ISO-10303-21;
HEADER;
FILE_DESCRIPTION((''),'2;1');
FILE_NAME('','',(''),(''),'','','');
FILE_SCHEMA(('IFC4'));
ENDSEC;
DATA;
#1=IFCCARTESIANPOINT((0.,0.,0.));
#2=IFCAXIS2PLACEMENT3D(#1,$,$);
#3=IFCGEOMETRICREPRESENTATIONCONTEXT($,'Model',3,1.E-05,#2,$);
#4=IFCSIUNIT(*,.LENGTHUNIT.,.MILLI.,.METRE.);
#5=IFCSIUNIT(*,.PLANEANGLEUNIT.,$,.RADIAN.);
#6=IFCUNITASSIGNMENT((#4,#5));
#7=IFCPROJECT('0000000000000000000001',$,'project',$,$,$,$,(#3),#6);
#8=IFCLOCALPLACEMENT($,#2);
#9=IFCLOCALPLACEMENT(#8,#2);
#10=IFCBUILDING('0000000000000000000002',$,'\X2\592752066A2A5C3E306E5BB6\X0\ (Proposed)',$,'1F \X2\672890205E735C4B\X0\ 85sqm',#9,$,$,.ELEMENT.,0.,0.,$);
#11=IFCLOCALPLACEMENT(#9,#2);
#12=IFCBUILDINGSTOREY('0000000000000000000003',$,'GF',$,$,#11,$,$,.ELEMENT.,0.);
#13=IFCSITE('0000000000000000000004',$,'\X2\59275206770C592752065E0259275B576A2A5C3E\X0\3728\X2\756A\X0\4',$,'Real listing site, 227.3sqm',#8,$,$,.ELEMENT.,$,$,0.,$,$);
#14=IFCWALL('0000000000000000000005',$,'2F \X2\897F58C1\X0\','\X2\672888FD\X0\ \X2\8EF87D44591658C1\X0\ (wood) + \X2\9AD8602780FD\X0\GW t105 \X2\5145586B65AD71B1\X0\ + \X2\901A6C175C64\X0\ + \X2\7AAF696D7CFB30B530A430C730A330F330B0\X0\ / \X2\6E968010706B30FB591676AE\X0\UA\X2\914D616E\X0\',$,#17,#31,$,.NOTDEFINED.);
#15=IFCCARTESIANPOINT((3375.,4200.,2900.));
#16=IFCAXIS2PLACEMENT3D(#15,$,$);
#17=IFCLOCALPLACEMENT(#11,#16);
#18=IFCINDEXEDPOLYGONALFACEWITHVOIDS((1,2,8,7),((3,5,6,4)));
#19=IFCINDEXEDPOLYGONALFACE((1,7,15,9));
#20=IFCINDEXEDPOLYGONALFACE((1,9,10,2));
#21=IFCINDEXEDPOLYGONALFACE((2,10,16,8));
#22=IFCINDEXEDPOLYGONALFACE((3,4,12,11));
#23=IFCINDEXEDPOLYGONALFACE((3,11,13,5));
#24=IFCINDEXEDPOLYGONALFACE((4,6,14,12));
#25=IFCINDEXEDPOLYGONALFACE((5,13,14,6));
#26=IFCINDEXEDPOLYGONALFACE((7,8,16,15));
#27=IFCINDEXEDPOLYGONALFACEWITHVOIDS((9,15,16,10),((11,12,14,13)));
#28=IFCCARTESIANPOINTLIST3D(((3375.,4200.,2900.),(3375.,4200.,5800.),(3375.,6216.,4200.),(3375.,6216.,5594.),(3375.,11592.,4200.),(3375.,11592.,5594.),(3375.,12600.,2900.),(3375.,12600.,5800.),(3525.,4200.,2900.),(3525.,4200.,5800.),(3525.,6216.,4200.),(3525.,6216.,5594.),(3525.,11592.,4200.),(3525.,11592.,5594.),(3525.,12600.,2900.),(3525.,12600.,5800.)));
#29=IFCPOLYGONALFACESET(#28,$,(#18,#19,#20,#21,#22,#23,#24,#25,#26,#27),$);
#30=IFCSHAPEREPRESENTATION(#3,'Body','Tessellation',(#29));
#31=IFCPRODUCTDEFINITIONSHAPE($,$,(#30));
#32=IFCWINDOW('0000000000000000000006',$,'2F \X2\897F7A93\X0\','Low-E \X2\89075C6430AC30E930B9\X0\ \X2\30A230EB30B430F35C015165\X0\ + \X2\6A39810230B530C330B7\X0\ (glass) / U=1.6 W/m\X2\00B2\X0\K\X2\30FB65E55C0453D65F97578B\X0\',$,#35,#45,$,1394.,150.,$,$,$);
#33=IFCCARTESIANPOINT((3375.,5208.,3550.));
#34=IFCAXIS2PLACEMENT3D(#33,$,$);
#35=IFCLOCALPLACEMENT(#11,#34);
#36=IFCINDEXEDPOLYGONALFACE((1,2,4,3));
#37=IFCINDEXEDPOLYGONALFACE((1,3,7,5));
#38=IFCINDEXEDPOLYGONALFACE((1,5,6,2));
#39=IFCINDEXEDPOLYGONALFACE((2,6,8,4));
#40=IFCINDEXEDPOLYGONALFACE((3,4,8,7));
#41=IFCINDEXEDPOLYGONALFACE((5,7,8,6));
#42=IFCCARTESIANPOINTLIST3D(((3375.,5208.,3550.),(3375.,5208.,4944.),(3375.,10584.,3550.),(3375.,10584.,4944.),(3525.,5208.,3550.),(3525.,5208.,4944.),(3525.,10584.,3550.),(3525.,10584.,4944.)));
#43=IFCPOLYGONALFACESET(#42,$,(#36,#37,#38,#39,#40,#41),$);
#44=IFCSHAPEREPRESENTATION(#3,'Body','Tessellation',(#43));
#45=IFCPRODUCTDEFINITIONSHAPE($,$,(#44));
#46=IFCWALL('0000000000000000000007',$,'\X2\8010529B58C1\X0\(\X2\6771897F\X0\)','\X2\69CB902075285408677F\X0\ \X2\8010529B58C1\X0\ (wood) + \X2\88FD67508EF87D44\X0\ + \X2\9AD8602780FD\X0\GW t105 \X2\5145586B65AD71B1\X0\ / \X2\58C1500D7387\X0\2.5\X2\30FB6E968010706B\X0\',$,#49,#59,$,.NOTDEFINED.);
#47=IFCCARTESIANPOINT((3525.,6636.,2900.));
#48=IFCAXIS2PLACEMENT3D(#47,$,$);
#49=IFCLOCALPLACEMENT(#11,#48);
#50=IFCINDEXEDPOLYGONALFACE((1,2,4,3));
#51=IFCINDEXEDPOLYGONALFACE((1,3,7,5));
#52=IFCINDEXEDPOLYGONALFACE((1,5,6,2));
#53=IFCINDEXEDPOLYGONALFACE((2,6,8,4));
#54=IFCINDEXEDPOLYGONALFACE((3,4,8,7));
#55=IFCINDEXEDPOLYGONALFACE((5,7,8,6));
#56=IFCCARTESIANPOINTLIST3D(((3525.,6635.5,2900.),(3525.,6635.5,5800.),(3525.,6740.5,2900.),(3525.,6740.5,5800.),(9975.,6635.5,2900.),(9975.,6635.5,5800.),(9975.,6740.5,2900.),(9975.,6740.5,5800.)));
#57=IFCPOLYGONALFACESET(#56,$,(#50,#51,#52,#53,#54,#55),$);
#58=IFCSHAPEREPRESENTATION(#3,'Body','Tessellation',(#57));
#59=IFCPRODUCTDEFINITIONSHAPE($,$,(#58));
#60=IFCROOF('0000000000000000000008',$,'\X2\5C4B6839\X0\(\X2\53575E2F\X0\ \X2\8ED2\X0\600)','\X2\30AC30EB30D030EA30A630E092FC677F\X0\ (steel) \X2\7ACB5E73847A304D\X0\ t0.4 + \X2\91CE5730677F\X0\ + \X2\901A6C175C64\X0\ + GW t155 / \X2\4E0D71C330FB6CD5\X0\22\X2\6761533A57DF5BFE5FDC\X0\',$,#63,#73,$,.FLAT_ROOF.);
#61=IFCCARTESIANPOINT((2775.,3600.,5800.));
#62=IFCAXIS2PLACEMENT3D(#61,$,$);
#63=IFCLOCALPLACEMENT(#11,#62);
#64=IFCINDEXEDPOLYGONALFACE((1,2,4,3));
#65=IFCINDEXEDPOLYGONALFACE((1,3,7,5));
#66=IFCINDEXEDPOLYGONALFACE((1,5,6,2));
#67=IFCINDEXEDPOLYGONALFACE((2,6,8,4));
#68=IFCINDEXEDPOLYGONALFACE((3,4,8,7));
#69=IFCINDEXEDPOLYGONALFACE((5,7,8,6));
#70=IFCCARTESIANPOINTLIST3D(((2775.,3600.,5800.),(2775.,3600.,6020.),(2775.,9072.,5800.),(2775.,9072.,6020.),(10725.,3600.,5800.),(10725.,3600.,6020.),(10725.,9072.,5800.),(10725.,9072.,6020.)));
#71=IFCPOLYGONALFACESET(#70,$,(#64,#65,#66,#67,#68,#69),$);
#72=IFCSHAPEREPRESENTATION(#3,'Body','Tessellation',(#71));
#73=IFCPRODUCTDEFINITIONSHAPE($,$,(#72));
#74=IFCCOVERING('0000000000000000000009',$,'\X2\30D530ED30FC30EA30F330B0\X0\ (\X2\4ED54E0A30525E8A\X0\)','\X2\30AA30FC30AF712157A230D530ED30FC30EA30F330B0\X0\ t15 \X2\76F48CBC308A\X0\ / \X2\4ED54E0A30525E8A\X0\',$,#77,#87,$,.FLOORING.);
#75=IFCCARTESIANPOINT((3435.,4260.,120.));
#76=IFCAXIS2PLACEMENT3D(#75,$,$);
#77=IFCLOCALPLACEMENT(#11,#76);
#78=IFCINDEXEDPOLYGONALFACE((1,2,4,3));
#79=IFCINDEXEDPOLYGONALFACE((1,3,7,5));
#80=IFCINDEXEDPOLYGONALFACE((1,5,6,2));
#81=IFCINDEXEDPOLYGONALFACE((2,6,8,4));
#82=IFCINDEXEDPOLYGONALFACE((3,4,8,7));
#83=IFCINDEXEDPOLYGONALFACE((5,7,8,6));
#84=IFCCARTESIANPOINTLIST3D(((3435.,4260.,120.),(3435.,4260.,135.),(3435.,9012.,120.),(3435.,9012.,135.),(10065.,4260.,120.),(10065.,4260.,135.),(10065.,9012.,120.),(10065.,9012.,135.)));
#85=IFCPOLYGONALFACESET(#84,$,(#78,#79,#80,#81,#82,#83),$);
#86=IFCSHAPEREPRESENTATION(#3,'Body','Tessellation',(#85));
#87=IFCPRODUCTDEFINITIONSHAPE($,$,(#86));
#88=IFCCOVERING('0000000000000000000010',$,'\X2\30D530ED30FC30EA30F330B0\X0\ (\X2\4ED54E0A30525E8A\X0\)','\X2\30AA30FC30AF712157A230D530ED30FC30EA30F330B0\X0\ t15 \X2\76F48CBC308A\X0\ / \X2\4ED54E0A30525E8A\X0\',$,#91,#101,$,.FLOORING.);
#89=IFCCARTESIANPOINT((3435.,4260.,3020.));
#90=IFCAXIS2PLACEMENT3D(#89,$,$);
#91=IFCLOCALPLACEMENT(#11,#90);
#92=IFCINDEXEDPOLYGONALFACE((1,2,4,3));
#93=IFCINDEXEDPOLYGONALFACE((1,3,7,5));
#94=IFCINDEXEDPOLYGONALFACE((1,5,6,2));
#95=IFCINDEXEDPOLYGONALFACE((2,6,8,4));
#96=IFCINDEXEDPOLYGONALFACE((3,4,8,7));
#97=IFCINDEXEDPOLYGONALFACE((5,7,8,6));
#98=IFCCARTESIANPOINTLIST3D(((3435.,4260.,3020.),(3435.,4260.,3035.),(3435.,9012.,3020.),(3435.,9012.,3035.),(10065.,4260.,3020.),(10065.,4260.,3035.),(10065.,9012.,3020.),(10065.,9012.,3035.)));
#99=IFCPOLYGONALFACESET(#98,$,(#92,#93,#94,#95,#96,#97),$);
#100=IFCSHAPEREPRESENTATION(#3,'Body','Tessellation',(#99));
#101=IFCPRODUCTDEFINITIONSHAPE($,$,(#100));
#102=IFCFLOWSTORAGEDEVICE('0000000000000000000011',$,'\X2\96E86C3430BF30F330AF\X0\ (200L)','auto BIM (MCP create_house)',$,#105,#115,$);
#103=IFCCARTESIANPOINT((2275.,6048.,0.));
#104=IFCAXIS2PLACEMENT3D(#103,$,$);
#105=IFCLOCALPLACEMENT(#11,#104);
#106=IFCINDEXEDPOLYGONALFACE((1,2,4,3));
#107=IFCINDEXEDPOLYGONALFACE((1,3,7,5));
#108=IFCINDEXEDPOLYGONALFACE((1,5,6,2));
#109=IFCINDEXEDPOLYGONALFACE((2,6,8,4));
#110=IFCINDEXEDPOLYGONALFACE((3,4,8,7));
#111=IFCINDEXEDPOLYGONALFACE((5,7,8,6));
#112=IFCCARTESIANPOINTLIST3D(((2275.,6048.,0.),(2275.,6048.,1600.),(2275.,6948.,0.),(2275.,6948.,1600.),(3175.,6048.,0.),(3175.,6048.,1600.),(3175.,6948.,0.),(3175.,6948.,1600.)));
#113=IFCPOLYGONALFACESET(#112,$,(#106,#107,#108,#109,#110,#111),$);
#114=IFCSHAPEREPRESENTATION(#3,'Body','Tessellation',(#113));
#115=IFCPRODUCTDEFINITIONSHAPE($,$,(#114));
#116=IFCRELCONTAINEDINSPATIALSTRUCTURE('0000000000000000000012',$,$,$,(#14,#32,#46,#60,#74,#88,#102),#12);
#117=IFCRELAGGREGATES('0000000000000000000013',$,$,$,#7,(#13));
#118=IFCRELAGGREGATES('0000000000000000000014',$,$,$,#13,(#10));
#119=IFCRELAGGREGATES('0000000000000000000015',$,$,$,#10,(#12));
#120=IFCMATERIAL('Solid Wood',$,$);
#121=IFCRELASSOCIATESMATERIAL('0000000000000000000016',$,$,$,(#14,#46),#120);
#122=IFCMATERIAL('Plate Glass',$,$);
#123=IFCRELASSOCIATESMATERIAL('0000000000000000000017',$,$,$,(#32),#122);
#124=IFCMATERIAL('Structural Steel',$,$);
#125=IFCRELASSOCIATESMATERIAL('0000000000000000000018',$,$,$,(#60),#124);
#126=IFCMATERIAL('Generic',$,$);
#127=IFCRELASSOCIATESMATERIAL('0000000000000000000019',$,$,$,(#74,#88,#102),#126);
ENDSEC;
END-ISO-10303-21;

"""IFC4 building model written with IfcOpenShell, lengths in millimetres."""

from ifc_helpers import new_model, si_unit, frame, frame_2d, origin, place, context, project, spatial, rectangle, extrude, material, element, fill, save


model = new_model("IFC4")

# Units and contexts
model_context = context("Model", 3, precision=1e-05, world=origin())
ifc_project = project(units=[si_unit("LENGTHUNIT", "METRE", prefix="MILLI"), si_unit("PLANEANGLEUNIT", "RADIAN")], contexts=[model_context])

# Site, building, storey
site_placement = place(None, origin())
site = spatial("IfcSite", under=ifc_project, at=site_placement, Name="大分県大分市大字横尾3728番4", ObjectType="Real listing site, 227.3sqm", CompositionType="ELEMENT", RefElevation=0.0)
building_placement = place(site_placement, origin())
building = spatial("IfcBuilding", under=site, at=building_placement, Name="大分横尾の家 (Proposed)", ObjectType="1F 木造平屋 85sqm", CompositionType="ELEMENT", ElevationOfRefHeight=0.0, ElevationOfTerrain=0.0)
storey_placement = place(building_placement, origin())
storey = spatial("IfcBuildingStorey", under=building, at=storey_placement, Name="GF", CompositionType="ELEMENT", Elevation=0.0)

# Shared definitions
ifc_material_1 = material(Name="Solid Wood")
ifc_material_2 = material(Name="Generic")

# Shared definitions
ifc_material_3 = material(Name="Plate Glass")

# Wall, opening, window
wall_1_placement = place(storey_placement, frame((3375.0, 4200.0, 2900.0)))
wall_1 = element("IfcWall", 1, at=wall_1_placement, inside=storey, material=ifc_material_1, Name="2F 西壁", Description="木製 軸組外壁 (wood) + 高性能GW t105 充填断熱 + 通気層 + 窯業系サイディング / 準耐火・外皮UA配慮", PredefinedType="NOTDEFINED", context=model_context, shape_type="SweptSolid", body=[
    extrude(rectangle(XDim=150.0, YDim=8400.0, at=frame_2d((75.0, 4200.0))), frame((3375.0, 4200.0, 2900.0)), (0.0, 0.0, 1.0), 2900.0),
])
opening_1_placement = place(storey_placement, frame((3375.0, 5208.0, 3550.0)))
opening_1 = element("IfcOpeningElement", 2, at=opening_1_placement, cuts=wall_1, PredefinedType="NOTDEFINED", context=model_context, shape_type="SweptSolid", body=[
    extrude(rectangle(XDim=150.0, YDim=5376.0, at=frame_2d((75.0, 2688.0))), frame((3375.0, 5208.0, 3550.0)), (0.0, 0.0, 1.0), 1394.0),
])
window_1_placement = place(storey_placement, frame((3375.0, 5208.0, 3550.0)))
window_1 = element("IfcWindow", 3, at=window_1_placement, inside=storey, material=ifc_material_3, Name="2F 西窓", Description="Low-E 複層ガラス アルゴン封入 + 樹脂サッシ (glass) / U=1.6 W/m²K・日射取得型", OverallHeight=1394.0, OverallWidth=150.0, context=model_context, shape_type="SweptSolid", body=[
    extrude(rectangle(XDim=150.0, YDim=5376.0, at=frame_2d((75.0, 2688.0))), frame((3375.0, 5208.0, 3550.0)), (0.0, 0.0, 1.0), 1394.0),
])
fill(opening_1, window_1)

# Wall
wall_2_placement = place(storey_placement, frame((3525.0, 6636.0, 2900.0)))
element("IfcWall", 4, at=wall_2_placement, inside=storey, material=ifc_material_1, Name="耐力壁(東西)", Description="構造用合板 耐力壁 (wood) + 製材軸組 + 高性能GW t105 充填断熱 / 壁倍率2.5・準耐火", PredefinedType="NOTDEFINED", context=model_context, shape_type="SweptSolid", body=[
    extrude(rectangle(XDim=6450.0, YDim=105.0, at=frame_2d((3225.0, 52.0))), frame((3525.0, 6636.0, 2900.0)), (0.0, 0.0, 1.0), 2900.0),
])

# Roof
ifc_material_4 = material(Name="Structural Steel")
for number, where, name in (
    (5, (2775.0, 3600.0, 5800.0), "屋根(南帯 軒600)"),
):
    element("IfcRoof", number, at=place(storey_placement, frame(where)), inside=storey, material=ifc_material_4, Name=name, Description="ガルバリウム鋼板 (steel) 立平葺き t0.4 + 野地板 + 通気層 + GW t155 / 不燃・法22条区域対応", PredefinedType="FLAT_ROOF", context=model_context, shape_type="SweptSolid", body=[
        extrude(rectangle(XDim=7950.0, YDim=5472.0, at=frame_2d((3975.0, 2736.0))), frame((2775.0, 3600.0, 5800.0)), (0.0, 0.0, 1.0), 220.0),
    ])

# Coverings
covering_1_placement = place(storey_placement, frame((3435.0, 4260.0, 120.0)))
element("IfcCovering", 6, at=covering_1_placement, inside=storey, material=ifc_material_2, Name="フローリング (仕上げ床)", Description="オーク無垢フローリング t15 直貼り / 仕上げ床", PredefinedType="FLOORING", context=model_context, shape_type="SweptSolid", body=[
    extrude(rectangle(XDim=6630.0, YDim=4752.0, at=frame_2d((3315.0, 2376.0))), frame((3435.0, 4260.0, 120.0)), (0.0, 0.0, 1.0), 15.0),
])
covering_2_placement = place(storey_placement, frame((3435.0, 4260.0, 3020.0)))
element("IfcCovering", 7, at=covering_2_placement, inside=storey, material=ifc_material_2, Name="フローリング (仕上げ床)", Description="オーク無垢フローリング t15 直貼り / 仕上げ床", PredefinedType="FLOORING", context=model_context, shape_type="SweptSolid", body=[
    extrude(rectangle(XDim=6630.0, YDim=4752.0, at=frame_2d((3315.0, 2376.0))), frame((3435.0, 4260.0, 3020.0)), (0.0, 0.0, 1.0), 15.0),
])

# Flow storage device
flow_storage_device_placement = place(storey_placement, frame((2275.0, 6048.0, 0.0)))
element("IfcFlowStorageDevice", 8, at=flow_storage_device_placement, inside=storey, material=ifc_material_2, Name="雨水タンク (200L)", Description="auto BIM (MCP create_house)", context=model_context, shape_type="SweptSolid", body=[
    extrude(rectangle(XDim=900.0, YDim=900.0, at=frame_2d((450.0, 450.0))), frame((2275.0, 6048.0, 0.0)), (0.0, 0.0, 1.0), 1600.0),
])

save(model, "model.ifc")
